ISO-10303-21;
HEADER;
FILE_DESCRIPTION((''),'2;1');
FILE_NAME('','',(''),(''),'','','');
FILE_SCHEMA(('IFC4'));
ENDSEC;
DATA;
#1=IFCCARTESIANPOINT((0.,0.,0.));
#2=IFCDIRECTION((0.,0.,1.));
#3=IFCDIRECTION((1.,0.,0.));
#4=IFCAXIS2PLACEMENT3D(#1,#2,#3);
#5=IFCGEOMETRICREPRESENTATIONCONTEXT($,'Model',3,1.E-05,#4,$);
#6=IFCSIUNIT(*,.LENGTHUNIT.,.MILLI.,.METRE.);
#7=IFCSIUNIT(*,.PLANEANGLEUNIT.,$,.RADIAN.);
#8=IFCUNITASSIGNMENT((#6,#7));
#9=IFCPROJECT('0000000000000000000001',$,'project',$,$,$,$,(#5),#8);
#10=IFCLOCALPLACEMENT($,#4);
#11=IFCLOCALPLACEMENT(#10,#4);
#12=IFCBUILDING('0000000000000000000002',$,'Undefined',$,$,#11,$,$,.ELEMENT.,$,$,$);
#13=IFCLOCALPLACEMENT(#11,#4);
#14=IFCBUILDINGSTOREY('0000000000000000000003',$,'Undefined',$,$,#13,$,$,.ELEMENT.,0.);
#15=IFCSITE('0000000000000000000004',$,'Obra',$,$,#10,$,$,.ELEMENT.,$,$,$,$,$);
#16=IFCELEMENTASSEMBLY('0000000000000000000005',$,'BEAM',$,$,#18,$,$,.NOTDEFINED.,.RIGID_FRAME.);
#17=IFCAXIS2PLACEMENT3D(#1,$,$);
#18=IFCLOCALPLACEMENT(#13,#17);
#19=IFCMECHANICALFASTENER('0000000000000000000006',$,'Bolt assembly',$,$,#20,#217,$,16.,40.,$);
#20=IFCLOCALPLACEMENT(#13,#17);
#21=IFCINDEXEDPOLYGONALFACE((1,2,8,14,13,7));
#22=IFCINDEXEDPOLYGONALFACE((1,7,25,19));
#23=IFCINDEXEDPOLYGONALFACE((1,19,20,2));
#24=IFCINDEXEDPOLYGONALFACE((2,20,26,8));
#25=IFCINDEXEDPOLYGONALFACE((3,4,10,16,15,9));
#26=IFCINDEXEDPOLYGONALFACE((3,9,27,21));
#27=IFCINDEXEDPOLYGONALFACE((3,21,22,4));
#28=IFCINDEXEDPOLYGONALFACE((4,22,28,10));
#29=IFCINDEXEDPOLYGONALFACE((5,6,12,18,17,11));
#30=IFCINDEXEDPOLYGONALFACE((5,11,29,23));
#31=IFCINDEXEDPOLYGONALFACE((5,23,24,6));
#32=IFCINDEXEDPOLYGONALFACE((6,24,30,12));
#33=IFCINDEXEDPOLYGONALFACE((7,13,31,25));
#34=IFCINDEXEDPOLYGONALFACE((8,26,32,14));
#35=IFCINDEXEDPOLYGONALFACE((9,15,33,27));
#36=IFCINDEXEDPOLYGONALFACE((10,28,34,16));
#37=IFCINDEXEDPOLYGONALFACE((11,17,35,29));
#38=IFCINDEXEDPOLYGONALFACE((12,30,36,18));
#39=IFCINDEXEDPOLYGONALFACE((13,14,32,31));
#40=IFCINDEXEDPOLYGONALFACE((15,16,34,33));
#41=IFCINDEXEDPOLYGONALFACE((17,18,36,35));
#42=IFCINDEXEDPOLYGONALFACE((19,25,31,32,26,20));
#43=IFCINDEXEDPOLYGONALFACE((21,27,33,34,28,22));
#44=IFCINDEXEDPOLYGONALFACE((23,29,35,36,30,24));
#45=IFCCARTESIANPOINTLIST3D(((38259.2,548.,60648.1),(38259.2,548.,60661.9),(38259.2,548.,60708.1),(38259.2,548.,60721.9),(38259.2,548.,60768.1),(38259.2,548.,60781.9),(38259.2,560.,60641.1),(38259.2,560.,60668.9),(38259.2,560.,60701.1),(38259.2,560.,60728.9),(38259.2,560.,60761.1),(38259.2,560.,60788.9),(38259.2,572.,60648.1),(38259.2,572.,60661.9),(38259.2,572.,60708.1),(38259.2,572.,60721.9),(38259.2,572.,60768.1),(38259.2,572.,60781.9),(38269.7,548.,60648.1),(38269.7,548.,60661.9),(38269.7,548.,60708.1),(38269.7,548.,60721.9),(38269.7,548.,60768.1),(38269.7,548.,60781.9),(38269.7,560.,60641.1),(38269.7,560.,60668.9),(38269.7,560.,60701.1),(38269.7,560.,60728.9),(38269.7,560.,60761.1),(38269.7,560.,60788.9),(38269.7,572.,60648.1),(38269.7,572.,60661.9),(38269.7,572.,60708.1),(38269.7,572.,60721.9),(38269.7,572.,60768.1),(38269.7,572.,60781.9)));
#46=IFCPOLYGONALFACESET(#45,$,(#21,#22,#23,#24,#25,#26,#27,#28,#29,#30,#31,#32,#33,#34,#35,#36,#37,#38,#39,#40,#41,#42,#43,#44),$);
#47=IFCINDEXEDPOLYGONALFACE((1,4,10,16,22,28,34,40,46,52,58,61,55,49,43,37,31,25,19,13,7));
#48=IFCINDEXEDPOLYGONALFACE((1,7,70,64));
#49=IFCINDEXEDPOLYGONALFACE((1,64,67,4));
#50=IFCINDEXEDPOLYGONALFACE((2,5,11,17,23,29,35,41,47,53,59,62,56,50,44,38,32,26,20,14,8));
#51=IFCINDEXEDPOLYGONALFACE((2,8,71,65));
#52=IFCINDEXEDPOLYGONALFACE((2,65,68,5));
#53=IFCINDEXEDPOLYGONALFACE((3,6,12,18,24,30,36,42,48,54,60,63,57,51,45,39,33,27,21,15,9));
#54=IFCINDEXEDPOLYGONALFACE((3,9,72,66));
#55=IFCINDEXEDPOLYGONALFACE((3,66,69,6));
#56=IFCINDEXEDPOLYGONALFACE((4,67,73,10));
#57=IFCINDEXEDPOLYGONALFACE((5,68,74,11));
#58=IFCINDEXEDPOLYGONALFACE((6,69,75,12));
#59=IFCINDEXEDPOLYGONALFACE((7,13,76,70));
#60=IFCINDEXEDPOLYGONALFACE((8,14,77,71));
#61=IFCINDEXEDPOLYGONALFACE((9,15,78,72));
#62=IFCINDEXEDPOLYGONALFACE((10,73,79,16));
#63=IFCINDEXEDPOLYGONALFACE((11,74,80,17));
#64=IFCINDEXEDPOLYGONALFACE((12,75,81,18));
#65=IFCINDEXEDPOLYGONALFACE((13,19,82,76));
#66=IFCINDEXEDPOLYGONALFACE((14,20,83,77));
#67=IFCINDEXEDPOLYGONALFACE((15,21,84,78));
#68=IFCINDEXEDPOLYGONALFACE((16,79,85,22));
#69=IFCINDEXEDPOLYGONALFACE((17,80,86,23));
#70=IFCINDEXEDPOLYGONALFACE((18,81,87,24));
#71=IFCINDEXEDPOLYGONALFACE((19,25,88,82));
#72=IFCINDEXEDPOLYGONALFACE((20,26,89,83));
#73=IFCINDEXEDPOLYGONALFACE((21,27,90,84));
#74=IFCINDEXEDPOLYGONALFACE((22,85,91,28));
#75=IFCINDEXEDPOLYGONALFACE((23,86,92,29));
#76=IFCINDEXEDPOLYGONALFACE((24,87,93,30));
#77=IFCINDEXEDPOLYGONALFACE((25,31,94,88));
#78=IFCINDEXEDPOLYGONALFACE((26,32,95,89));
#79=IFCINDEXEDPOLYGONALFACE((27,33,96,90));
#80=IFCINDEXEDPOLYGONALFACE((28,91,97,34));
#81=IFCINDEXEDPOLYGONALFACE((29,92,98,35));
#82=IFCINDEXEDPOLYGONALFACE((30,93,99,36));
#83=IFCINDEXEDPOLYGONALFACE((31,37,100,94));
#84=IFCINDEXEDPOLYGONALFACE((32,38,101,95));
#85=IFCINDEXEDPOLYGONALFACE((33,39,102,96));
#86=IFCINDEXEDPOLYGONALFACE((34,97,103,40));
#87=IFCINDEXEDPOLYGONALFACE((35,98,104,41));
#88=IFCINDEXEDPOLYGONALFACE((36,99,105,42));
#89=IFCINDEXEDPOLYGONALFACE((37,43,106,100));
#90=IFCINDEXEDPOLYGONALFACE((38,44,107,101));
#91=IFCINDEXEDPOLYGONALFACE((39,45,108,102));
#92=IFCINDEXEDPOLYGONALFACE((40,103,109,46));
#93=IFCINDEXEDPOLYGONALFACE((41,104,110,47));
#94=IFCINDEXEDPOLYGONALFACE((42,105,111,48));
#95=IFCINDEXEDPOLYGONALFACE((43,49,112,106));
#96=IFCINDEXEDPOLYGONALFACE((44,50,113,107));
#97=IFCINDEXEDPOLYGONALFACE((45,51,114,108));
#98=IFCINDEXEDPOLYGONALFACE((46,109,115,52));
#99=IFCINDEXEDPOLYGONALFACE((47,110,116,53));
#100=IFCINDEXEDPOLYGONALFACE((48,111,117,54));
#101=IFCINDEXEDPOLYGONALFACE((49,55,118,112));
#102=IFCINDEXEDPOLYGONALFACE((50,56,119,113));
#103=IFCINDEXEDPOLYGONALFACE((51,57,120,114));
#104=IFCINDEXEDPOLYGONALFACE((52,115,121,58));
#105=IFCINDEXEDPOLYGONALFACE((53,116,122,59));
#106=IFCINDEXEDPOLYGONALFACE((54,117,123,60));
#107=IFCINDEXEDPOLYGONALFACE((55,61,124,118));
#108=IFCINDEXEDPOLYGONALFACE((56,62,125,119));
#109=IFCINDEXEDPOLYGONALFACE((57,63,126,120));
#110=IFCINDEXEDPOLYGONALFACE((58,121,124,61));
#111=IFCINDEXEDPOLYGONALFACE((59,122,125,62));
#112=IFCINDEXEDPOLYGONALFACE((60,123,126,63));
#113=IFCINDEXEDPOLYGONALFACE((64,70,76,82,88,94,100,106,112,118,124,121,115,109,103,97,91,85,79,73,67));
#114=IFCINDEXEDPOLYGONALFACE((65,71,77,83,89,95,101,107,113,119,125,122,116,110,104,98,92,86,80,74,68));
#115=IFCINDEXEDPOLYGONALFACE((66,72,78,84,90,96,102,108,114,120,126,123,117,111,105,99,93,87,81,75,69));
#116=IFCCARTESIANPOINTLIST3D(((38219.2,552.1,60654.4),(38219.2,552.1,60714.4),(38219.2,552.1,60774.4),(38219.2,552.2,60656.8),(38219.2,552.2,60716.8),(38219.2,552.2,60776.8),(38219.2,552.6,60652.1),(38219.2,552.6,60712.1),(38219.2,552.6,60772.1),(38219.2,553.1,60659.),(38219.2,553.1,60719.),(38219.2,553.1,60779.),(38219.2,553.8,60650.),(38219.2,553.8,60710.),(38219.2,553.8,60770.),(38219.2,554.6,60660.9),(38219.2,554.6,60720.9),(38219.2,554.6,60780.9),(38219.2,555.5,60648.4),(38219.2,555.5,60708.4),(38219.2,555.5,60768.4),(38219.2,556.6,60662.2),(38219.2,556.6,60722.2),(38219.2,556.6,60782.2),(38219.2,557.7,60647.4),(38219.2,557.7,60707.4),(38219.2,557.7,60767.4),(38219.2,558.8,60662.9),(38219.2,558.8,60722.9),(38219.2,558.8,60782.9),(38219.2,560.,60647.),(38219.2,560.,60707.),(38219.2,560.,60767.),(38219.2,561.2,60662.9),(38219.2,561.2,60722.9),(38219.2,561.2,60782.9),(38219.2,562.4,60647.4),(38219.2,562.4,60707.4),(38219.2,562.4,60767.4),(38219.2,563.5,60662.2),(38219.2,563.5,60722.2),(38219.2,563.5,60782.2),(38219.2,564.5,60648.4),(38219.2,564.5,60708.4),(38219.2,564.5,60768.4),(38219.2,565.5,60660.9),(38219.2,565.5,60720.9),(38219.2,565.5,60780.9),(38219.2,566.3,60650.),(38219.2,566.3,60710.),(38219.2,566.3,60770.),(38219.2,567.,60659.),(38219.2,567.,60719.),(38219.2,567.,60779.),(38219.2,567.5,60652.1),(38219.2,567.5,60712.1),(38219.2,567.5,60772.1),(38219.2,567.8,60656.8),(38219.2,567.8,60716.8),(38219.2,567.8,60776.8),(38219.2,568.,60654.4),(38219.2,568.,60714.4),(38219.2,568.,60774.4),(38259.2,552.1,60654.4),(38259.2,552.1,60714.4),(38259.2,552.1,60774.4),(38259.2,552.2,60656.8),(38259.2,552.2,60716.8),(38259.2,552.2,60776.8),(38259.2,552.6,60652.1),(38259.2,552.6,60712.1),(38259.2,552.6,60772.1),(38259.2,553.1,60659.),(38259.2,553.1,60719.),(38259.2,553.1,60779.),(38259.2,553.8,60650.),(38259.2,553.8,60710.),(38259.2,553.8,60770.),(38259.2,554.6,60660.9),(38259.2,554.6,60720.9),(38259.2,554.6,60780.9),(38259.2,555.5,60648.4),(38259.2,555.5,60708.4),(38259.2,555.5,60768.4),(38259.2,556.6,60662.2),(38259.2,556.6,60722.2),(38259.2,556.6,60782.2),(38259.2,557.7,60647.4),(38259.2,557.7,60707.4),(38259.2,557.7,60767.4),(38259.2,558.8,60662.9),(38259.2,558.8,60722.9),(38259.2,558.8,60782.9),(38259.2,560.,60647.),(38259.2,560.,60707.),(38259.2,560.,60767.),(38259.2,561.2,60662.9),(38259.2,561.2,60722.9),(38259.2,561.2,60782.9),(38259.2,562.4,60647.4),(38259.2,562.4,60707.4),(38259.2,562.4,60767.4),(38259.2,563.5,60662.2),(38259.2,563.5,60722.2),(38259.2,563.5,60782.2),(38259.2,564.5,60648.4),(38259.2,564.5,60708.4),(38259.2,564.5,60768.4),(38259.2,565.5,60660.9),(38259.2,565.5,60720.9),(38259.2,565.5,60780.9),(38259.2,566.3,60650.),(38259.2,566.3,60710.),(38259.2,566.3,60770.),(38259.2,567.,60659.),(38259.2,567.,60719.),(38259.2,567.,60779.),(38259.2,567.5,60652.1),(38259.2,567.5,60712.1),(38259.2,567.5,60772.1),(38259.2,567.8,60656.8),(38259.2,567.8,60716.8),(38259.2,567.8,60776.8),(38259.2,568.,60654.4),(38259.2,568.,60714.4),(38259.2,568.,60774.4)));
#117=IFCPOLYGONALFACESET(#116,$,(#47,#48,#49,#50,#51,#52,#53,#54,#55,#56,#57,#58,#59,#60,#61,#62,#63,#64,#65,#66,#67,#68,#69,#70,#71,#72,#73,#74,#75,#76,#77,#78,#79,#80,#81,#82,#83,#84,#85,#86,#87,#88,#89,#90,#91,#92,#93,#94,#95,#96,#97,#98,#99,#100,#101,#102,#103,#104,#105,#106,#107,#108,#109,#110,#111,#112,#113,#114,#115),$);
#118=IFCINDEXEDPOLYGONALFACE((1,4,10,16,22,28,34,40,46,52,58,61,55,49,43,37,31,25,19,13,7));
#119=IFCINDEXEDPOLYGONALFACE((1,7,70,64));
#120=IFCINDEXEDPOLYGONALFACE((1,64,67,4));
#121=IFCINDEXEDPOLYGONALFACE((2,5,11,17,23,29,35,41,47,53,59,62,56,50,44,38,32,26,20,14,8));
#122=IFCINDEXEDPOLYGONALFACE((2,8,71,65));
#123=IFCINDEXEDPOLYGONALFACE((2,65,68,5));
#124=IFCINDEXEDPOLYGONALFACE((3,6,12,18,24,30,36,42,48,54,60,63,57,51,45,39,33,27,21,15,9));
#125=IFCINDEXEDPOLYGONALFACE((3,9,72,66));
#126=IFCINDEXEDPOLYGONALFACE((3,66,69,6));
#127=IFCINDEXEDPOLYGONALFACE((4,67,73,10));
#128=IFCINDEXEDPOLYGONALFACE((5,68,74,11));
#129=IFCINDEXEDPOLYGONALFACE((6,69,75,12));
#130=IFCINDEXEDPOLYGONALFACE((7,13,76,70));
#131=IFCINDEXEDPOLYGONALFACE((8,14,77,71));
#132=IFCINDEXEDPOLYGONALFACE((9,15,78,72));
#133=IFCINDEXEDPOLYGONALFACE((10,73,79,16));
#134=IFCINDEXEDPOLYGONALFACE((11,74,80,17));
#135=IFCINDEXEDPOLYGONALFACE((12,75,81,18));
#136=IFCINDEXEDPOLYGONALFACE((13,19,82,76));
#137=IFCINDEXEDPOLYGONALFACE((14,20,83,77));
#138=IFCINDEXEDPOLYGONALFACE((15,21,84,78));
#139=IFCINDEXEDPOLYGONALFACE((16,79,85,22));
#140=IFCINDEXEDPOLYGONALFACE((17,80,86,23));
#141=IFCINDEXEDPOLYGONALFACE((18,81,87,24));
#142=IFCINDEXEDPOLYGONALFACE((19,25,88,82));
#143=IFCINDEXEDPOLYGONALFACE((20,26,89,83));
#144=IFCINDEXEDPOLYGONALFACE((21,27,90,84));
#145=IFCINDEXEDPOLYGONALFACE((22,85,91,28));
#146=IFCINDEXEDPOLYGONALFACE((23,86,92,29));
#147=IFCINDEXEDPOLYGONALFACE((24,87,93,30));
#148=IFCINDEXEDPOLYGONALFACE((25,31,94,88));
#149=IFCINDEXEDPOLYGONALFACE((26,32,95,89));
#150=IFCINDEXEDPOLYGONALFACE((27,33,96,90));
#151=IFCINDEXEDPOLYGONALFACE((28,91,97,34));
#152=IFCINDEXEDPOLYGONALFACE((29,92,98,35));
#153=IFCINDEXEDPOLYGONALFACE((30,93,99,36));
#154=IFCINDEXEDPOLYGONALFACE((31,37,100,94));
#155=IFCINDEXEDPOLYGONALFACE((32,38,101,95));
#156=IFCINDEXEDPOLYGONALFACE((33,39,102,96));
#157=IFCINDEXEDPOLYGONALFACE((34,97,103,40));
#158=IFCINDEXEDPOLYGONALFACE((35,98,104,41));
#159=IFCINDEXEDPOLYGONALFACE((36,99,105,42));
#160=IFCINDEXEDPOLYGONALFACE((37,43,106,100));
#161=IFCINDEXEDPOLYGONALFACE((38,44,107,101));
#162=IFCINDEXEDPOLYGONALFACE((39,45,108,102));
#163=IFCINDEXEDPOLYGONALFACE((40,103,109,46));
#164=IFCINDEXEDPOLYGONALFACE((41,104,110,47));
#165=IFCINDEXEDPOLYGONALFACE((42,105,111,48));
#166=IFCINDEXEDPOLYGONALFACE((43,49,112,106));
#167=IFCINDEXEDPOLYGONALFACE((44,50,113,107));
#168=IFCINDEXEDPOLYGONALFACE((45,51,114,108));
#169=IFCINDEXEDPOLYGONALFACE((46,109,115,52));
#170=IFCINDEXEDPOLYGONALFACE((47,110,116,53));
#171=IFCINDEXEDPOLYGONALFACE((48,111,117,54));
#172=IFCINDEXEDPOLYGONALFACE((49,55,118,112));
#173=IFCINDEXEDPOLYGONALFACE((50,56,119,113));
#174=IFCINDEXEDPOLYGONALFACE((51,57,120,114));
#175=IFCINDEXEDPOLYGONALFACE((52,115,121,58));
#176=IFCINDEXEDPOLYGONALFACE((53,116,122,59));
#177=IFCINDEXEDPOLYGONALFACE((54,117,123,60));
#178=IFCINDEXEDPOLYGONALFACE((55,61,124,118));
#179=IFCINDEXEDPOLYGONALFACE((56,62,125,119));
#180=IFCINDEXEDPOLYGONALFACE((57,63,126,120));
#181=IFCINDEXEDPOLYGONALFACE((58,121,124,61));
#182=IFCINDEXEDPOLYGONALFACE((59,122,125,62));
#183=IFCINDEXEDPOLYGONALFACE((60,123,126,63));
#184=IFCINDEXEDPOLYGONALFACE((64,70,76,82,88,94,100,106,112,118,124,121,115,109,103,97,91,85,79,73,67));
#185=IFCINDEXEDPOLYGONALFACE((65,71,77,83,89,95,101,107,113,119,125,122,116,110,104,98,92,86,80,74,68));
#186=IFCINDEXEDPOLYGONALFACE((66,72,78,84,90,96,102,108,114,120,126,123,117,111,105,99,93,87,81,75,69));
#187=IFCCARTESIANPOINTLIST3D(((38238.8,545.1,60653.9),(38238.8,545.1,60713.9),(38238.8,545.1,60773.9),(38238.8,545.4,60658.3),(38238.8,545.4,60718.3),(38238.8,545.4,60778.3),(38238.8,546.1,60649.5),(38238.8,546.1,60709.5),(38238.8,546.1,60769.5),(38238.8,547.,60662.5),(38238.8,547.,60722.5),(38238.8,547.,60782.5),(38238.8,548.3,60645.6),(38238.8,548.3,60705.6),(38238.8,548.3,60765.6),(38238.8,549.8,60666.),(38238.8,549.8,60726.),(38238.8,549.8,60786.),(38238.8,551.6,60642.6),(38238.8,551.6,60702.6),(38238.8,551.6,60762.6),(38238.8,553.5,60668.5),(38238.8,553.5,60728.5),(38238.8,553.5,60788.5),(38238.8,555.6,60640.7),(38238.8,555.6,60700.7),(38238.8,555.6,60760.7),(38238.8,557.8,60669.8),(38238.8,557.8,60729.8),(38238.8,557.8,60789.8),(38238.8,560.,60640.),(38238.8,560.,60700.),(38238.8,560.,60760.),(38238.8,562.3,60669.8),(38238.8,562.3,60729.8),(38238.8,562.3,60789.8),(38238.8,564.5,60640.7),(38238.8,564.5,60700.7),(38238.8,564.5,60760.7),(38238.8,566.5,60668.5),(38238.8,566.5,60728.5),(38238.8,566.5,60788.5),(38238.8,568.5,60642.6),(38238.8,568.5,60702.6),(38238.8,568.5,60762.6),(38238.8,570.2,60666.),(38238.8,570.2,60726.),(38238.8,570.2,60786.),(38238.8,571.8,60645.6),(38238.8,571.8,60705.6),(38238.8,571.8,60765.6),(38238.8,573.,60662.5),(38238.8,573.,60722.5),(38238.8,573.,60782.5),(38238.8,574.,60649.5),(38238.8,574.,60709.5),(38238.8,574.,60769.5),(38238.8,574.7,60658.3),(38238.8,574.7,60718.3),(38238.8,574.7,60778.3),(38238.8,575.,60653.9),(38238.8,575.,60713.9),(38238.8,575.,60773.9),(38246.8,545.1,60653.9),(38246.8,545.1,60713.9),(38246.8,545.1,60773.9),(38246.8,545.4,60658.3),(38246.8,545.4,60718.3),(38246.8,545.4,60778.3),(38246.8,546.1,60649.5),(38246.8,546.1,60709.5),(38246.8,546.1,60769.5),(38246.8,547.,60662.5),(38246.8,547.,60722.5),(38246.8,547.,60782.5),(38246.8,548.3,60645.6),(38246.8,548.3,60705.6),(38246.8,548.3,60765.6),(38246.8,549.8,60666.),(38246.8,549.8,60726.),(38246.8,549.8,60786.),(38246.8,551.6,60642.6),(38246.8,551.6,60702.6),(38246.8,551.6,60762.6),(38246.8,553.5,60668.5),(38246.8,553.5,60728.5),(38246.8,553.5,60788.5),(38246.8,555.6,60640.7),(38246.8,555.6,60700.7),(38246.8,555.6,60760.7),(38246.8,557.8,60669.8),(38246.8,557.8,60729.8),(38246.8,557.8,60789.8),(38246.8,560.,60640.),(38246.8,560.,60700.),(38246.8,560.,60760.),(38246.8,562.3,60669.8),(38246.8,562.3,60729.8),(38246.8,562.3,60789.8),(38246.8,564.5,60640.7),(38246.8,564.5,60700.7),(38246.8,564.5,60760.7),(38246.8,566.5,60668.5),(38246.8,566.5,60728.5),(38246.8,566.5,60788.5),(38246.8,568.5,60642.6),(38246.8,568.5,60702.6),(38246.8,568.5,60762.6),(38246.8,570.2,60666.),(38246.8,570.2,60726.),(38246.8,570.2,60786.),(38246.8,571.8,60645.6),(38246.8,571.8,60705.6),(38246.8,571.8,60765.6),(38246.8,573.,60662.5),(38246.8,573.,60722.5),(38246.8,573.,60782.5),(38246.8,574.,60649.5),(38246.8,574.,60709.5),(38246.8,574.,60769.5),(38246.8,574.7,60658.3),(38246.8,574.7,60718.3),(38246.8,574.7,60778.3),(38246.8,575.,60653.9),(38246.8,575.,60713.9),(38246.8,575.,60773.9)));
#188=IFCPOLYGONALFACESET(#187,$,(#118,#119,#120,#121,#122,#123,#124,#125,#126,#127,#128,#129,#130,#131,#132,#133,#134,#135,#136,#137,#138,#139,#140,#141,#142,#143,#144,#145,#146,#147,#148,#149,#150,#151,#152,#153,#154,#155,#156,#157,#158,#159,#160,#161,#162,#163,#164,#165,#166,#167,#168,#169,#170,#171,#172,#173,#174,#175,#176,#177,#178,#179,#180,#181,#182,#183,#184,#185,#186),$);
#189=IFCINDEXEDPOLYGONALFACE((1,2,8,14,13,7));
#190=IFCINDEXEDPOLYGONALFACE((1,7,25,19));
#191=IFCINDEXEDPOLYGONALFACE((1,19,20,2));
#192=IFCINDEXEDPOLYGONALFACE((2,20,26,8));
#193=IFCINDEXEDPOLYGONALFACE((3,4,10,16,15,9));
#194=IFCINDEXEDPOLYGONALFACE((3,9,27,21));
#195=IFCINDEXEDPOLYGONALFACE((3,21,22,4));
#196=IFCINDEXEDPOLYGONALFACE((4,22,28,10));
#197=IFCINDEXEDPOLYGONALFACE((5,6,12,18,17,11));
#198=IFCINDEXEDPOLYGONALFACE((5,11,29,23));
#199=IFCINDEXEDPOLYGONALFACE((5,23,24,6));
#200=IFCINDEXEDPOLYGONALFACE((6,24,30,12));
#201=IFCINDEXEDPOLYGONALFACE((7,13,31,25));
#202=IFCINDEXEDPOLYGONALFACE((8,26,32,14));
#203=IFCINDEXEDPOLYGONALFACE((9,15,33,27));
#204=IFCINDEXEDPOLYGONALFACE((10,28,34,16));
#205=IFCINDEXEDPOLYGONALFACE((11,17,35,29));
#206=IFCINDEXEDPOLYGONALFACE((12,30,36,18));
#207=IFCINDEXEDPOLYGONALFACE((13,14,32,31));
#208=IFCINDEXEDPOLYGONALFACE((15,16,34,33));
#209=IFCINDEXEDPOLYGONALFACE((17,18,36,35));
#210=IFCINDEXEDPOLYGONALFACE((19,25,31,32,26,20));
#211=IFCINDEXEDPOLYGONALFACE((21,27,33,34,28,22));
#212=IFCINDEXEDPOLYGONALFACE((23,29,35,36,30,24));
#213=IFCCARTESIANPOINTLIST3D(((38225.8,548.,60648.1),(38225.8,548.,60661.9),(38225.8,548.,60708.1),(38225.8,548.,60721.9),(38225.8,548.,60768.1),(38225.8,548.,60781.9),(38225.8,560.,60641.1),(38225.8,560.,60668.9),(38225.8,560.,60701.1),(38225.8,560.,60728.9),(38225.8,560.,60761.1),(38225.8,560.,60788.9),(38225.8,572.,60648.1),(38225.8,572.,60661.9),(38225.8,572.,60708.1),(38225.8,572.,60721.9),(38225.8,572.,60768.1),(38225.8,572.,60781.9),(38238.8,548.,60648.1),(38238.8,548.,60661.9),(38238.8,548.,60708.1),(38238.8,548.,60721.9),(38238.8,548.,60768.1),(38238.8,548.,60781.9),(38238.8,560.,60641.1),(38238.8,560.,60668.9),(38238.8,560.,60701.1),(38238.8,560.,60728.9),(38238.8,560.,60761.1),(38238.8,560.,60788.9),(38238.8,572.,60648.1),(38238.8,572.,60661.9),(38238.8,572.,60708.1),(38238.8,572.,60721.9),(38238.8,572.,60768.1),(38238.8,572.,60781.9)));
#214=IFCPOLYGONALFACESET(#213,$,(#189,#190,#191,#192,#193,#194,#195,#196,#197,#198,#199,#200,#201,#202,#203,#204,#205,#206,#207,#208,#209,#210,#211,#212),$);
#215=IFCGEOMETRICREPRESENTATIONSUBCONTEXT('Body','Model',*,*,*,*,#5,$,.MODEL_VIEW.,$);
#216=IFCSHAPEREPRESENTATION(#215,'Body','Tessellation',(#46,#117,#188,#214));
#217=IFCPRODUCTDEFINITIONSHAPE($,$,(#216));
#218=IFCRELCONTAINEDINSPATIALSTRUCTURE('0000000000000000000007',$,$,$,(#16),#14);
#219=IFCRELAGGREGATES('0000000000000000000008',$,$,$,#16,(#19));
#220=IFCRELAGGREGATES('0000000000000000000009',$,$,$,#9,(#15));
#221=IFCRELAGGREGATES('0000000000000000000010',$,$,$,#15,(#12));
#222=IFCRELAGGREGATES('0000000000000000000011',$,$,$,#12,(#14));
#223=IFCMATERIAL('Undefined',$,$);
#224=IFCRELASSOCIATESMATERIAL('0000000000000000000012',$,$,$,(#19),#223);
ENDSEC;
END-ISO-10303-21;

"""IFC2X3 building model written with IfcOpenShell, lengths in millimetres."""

from ifc_helpers import new_model, si_unit, frame, origin_with_axes, origin_2d_with_axis, place, context, subcontext, project, spatial, polyline, circle, outline, extrude, source, transform, mapped, material, element, aggregate, save


model = new_model("IFC2X3")

# Units and contexts
model_context = context("Model", 3, precision=1e-05, world=origin_with_axes())
body_context = subcontext(model_context, "Body", "Model", "MODEL_VIEW")
ifc_project = project(units=[si_unit("LENGTHUNIT", "METRE", prefix="MILLI"), si_unit("PLANEANGLEUNIT", "RADIAN")], contexts=[model_context])

# Site, building, storey
site_placement = place(None, origin_with_axes())
site = spatial("IfcSite", under=ifc_project, at=site_placement, Name="Obra", CompositionType="ELEMENT")
building_placement = place(site_placement, origin_with_axes())
building = spatial("IfcBuilding", under=site, at=building_placement, Name="Undefined", CompositionType="ELEMENT")
storey_placement = place(building_placement, origin_with_axes())
storey = spatial("IfcBuildingStorey", under=building, at=storey_placement, Name="Undefined", CompositionType="ELEMENT", Elevation=0.0)

# Element assembly
ifc_material_1 = material(Name="Undefined")
assembly_1_placement = place(storey_placement, origin_with_axes())
assembly_1 = element("IfcElementAssembly", 1, at=assembly_1_placement, inside=storey, Name="BEAM", AssemblyPlace="NOTDEFINED", PredefinedType="RIGID_FRAME")

# Mechanical fastener
shared_shape_1 = source(origin_with_axes(), body_context, "Body", "SweptSolid", [
    extrude(outline(polyline([(13.9, 0.0), (6.9, 12.0), (-6.9, 12.0), (-13.9, 0.0), (-6.9, -12.0), (6.9, -12.0), (13.9, 0.0)])), frame((0.0, -19.7, 0.0), z_axis=(0.0, 1.0, 0.0), x_axis=(1.0, 0.0, 0.0)), (0.0, 0.0, 1.0), 10.6),
    extrude(circle(Radius=8.0, at=origin_2d_with_axis()), frame((0.0, -9.1, 0.0), z_axis=(0.0, 1.0, 0.0), x_axis=(1.0, 0.0, 0.0)), (0.0, 0.0, 1.0), 40.0),
    extrude(circle(Radius=15.0, at=origin_2d_with_axis()), frame((0.0, 3.3, 0.0), z_axis=(0.0, 1.0, 0.0), x_axis=(1.0, 0.0, 0.0)), (0.0, 0.0, 1.0), 8.0),
    extrude(outline(polyline([(13.9, 0.0), (6.9, 12.0), (-6.9, 12.0), (-13.9, 0.0), (-6.9, -12.0), (6.9, -12.0), (13.9, 0.0)])), frame((0.0, 11.3, 0.0), z_axis=(0.0, 1.0, 0.0), x_axis=(1.0, 0.0, 0.0)), (0.0, 0.0, 1.0), 13.0),
])
mechanical_fastener_1_placement = place(assembly_1_placement, frame((38250.1, 510.0, 60835.0), z_axis=(-0.000002, 1.0, 0.0), x_axis=(0.0, 0.0, -1.0)))
mechanical_fastener_1 = element("IfcMechanicalFastener", 2, at=mechanical_fastener_1_placement, material=ifc_material_1, Name="Bolt assembly", NominalDiameter=16.0, NominalLength=40.0, context=body_context, shape_type="MappedRepresentation", body=[
    mapped(shared_shape_1, transform((60.0, 0.0, 50.0))),
    mapped(shared_shape_1, transform((120.0, 0.0, 50.0))),
    mapped(shared_shape_1, transform((180.0, 0.0, 50.0))),
])
aggregate(assembly_1, [mechanical_fastener_1])

save(model, "model.ifc")
